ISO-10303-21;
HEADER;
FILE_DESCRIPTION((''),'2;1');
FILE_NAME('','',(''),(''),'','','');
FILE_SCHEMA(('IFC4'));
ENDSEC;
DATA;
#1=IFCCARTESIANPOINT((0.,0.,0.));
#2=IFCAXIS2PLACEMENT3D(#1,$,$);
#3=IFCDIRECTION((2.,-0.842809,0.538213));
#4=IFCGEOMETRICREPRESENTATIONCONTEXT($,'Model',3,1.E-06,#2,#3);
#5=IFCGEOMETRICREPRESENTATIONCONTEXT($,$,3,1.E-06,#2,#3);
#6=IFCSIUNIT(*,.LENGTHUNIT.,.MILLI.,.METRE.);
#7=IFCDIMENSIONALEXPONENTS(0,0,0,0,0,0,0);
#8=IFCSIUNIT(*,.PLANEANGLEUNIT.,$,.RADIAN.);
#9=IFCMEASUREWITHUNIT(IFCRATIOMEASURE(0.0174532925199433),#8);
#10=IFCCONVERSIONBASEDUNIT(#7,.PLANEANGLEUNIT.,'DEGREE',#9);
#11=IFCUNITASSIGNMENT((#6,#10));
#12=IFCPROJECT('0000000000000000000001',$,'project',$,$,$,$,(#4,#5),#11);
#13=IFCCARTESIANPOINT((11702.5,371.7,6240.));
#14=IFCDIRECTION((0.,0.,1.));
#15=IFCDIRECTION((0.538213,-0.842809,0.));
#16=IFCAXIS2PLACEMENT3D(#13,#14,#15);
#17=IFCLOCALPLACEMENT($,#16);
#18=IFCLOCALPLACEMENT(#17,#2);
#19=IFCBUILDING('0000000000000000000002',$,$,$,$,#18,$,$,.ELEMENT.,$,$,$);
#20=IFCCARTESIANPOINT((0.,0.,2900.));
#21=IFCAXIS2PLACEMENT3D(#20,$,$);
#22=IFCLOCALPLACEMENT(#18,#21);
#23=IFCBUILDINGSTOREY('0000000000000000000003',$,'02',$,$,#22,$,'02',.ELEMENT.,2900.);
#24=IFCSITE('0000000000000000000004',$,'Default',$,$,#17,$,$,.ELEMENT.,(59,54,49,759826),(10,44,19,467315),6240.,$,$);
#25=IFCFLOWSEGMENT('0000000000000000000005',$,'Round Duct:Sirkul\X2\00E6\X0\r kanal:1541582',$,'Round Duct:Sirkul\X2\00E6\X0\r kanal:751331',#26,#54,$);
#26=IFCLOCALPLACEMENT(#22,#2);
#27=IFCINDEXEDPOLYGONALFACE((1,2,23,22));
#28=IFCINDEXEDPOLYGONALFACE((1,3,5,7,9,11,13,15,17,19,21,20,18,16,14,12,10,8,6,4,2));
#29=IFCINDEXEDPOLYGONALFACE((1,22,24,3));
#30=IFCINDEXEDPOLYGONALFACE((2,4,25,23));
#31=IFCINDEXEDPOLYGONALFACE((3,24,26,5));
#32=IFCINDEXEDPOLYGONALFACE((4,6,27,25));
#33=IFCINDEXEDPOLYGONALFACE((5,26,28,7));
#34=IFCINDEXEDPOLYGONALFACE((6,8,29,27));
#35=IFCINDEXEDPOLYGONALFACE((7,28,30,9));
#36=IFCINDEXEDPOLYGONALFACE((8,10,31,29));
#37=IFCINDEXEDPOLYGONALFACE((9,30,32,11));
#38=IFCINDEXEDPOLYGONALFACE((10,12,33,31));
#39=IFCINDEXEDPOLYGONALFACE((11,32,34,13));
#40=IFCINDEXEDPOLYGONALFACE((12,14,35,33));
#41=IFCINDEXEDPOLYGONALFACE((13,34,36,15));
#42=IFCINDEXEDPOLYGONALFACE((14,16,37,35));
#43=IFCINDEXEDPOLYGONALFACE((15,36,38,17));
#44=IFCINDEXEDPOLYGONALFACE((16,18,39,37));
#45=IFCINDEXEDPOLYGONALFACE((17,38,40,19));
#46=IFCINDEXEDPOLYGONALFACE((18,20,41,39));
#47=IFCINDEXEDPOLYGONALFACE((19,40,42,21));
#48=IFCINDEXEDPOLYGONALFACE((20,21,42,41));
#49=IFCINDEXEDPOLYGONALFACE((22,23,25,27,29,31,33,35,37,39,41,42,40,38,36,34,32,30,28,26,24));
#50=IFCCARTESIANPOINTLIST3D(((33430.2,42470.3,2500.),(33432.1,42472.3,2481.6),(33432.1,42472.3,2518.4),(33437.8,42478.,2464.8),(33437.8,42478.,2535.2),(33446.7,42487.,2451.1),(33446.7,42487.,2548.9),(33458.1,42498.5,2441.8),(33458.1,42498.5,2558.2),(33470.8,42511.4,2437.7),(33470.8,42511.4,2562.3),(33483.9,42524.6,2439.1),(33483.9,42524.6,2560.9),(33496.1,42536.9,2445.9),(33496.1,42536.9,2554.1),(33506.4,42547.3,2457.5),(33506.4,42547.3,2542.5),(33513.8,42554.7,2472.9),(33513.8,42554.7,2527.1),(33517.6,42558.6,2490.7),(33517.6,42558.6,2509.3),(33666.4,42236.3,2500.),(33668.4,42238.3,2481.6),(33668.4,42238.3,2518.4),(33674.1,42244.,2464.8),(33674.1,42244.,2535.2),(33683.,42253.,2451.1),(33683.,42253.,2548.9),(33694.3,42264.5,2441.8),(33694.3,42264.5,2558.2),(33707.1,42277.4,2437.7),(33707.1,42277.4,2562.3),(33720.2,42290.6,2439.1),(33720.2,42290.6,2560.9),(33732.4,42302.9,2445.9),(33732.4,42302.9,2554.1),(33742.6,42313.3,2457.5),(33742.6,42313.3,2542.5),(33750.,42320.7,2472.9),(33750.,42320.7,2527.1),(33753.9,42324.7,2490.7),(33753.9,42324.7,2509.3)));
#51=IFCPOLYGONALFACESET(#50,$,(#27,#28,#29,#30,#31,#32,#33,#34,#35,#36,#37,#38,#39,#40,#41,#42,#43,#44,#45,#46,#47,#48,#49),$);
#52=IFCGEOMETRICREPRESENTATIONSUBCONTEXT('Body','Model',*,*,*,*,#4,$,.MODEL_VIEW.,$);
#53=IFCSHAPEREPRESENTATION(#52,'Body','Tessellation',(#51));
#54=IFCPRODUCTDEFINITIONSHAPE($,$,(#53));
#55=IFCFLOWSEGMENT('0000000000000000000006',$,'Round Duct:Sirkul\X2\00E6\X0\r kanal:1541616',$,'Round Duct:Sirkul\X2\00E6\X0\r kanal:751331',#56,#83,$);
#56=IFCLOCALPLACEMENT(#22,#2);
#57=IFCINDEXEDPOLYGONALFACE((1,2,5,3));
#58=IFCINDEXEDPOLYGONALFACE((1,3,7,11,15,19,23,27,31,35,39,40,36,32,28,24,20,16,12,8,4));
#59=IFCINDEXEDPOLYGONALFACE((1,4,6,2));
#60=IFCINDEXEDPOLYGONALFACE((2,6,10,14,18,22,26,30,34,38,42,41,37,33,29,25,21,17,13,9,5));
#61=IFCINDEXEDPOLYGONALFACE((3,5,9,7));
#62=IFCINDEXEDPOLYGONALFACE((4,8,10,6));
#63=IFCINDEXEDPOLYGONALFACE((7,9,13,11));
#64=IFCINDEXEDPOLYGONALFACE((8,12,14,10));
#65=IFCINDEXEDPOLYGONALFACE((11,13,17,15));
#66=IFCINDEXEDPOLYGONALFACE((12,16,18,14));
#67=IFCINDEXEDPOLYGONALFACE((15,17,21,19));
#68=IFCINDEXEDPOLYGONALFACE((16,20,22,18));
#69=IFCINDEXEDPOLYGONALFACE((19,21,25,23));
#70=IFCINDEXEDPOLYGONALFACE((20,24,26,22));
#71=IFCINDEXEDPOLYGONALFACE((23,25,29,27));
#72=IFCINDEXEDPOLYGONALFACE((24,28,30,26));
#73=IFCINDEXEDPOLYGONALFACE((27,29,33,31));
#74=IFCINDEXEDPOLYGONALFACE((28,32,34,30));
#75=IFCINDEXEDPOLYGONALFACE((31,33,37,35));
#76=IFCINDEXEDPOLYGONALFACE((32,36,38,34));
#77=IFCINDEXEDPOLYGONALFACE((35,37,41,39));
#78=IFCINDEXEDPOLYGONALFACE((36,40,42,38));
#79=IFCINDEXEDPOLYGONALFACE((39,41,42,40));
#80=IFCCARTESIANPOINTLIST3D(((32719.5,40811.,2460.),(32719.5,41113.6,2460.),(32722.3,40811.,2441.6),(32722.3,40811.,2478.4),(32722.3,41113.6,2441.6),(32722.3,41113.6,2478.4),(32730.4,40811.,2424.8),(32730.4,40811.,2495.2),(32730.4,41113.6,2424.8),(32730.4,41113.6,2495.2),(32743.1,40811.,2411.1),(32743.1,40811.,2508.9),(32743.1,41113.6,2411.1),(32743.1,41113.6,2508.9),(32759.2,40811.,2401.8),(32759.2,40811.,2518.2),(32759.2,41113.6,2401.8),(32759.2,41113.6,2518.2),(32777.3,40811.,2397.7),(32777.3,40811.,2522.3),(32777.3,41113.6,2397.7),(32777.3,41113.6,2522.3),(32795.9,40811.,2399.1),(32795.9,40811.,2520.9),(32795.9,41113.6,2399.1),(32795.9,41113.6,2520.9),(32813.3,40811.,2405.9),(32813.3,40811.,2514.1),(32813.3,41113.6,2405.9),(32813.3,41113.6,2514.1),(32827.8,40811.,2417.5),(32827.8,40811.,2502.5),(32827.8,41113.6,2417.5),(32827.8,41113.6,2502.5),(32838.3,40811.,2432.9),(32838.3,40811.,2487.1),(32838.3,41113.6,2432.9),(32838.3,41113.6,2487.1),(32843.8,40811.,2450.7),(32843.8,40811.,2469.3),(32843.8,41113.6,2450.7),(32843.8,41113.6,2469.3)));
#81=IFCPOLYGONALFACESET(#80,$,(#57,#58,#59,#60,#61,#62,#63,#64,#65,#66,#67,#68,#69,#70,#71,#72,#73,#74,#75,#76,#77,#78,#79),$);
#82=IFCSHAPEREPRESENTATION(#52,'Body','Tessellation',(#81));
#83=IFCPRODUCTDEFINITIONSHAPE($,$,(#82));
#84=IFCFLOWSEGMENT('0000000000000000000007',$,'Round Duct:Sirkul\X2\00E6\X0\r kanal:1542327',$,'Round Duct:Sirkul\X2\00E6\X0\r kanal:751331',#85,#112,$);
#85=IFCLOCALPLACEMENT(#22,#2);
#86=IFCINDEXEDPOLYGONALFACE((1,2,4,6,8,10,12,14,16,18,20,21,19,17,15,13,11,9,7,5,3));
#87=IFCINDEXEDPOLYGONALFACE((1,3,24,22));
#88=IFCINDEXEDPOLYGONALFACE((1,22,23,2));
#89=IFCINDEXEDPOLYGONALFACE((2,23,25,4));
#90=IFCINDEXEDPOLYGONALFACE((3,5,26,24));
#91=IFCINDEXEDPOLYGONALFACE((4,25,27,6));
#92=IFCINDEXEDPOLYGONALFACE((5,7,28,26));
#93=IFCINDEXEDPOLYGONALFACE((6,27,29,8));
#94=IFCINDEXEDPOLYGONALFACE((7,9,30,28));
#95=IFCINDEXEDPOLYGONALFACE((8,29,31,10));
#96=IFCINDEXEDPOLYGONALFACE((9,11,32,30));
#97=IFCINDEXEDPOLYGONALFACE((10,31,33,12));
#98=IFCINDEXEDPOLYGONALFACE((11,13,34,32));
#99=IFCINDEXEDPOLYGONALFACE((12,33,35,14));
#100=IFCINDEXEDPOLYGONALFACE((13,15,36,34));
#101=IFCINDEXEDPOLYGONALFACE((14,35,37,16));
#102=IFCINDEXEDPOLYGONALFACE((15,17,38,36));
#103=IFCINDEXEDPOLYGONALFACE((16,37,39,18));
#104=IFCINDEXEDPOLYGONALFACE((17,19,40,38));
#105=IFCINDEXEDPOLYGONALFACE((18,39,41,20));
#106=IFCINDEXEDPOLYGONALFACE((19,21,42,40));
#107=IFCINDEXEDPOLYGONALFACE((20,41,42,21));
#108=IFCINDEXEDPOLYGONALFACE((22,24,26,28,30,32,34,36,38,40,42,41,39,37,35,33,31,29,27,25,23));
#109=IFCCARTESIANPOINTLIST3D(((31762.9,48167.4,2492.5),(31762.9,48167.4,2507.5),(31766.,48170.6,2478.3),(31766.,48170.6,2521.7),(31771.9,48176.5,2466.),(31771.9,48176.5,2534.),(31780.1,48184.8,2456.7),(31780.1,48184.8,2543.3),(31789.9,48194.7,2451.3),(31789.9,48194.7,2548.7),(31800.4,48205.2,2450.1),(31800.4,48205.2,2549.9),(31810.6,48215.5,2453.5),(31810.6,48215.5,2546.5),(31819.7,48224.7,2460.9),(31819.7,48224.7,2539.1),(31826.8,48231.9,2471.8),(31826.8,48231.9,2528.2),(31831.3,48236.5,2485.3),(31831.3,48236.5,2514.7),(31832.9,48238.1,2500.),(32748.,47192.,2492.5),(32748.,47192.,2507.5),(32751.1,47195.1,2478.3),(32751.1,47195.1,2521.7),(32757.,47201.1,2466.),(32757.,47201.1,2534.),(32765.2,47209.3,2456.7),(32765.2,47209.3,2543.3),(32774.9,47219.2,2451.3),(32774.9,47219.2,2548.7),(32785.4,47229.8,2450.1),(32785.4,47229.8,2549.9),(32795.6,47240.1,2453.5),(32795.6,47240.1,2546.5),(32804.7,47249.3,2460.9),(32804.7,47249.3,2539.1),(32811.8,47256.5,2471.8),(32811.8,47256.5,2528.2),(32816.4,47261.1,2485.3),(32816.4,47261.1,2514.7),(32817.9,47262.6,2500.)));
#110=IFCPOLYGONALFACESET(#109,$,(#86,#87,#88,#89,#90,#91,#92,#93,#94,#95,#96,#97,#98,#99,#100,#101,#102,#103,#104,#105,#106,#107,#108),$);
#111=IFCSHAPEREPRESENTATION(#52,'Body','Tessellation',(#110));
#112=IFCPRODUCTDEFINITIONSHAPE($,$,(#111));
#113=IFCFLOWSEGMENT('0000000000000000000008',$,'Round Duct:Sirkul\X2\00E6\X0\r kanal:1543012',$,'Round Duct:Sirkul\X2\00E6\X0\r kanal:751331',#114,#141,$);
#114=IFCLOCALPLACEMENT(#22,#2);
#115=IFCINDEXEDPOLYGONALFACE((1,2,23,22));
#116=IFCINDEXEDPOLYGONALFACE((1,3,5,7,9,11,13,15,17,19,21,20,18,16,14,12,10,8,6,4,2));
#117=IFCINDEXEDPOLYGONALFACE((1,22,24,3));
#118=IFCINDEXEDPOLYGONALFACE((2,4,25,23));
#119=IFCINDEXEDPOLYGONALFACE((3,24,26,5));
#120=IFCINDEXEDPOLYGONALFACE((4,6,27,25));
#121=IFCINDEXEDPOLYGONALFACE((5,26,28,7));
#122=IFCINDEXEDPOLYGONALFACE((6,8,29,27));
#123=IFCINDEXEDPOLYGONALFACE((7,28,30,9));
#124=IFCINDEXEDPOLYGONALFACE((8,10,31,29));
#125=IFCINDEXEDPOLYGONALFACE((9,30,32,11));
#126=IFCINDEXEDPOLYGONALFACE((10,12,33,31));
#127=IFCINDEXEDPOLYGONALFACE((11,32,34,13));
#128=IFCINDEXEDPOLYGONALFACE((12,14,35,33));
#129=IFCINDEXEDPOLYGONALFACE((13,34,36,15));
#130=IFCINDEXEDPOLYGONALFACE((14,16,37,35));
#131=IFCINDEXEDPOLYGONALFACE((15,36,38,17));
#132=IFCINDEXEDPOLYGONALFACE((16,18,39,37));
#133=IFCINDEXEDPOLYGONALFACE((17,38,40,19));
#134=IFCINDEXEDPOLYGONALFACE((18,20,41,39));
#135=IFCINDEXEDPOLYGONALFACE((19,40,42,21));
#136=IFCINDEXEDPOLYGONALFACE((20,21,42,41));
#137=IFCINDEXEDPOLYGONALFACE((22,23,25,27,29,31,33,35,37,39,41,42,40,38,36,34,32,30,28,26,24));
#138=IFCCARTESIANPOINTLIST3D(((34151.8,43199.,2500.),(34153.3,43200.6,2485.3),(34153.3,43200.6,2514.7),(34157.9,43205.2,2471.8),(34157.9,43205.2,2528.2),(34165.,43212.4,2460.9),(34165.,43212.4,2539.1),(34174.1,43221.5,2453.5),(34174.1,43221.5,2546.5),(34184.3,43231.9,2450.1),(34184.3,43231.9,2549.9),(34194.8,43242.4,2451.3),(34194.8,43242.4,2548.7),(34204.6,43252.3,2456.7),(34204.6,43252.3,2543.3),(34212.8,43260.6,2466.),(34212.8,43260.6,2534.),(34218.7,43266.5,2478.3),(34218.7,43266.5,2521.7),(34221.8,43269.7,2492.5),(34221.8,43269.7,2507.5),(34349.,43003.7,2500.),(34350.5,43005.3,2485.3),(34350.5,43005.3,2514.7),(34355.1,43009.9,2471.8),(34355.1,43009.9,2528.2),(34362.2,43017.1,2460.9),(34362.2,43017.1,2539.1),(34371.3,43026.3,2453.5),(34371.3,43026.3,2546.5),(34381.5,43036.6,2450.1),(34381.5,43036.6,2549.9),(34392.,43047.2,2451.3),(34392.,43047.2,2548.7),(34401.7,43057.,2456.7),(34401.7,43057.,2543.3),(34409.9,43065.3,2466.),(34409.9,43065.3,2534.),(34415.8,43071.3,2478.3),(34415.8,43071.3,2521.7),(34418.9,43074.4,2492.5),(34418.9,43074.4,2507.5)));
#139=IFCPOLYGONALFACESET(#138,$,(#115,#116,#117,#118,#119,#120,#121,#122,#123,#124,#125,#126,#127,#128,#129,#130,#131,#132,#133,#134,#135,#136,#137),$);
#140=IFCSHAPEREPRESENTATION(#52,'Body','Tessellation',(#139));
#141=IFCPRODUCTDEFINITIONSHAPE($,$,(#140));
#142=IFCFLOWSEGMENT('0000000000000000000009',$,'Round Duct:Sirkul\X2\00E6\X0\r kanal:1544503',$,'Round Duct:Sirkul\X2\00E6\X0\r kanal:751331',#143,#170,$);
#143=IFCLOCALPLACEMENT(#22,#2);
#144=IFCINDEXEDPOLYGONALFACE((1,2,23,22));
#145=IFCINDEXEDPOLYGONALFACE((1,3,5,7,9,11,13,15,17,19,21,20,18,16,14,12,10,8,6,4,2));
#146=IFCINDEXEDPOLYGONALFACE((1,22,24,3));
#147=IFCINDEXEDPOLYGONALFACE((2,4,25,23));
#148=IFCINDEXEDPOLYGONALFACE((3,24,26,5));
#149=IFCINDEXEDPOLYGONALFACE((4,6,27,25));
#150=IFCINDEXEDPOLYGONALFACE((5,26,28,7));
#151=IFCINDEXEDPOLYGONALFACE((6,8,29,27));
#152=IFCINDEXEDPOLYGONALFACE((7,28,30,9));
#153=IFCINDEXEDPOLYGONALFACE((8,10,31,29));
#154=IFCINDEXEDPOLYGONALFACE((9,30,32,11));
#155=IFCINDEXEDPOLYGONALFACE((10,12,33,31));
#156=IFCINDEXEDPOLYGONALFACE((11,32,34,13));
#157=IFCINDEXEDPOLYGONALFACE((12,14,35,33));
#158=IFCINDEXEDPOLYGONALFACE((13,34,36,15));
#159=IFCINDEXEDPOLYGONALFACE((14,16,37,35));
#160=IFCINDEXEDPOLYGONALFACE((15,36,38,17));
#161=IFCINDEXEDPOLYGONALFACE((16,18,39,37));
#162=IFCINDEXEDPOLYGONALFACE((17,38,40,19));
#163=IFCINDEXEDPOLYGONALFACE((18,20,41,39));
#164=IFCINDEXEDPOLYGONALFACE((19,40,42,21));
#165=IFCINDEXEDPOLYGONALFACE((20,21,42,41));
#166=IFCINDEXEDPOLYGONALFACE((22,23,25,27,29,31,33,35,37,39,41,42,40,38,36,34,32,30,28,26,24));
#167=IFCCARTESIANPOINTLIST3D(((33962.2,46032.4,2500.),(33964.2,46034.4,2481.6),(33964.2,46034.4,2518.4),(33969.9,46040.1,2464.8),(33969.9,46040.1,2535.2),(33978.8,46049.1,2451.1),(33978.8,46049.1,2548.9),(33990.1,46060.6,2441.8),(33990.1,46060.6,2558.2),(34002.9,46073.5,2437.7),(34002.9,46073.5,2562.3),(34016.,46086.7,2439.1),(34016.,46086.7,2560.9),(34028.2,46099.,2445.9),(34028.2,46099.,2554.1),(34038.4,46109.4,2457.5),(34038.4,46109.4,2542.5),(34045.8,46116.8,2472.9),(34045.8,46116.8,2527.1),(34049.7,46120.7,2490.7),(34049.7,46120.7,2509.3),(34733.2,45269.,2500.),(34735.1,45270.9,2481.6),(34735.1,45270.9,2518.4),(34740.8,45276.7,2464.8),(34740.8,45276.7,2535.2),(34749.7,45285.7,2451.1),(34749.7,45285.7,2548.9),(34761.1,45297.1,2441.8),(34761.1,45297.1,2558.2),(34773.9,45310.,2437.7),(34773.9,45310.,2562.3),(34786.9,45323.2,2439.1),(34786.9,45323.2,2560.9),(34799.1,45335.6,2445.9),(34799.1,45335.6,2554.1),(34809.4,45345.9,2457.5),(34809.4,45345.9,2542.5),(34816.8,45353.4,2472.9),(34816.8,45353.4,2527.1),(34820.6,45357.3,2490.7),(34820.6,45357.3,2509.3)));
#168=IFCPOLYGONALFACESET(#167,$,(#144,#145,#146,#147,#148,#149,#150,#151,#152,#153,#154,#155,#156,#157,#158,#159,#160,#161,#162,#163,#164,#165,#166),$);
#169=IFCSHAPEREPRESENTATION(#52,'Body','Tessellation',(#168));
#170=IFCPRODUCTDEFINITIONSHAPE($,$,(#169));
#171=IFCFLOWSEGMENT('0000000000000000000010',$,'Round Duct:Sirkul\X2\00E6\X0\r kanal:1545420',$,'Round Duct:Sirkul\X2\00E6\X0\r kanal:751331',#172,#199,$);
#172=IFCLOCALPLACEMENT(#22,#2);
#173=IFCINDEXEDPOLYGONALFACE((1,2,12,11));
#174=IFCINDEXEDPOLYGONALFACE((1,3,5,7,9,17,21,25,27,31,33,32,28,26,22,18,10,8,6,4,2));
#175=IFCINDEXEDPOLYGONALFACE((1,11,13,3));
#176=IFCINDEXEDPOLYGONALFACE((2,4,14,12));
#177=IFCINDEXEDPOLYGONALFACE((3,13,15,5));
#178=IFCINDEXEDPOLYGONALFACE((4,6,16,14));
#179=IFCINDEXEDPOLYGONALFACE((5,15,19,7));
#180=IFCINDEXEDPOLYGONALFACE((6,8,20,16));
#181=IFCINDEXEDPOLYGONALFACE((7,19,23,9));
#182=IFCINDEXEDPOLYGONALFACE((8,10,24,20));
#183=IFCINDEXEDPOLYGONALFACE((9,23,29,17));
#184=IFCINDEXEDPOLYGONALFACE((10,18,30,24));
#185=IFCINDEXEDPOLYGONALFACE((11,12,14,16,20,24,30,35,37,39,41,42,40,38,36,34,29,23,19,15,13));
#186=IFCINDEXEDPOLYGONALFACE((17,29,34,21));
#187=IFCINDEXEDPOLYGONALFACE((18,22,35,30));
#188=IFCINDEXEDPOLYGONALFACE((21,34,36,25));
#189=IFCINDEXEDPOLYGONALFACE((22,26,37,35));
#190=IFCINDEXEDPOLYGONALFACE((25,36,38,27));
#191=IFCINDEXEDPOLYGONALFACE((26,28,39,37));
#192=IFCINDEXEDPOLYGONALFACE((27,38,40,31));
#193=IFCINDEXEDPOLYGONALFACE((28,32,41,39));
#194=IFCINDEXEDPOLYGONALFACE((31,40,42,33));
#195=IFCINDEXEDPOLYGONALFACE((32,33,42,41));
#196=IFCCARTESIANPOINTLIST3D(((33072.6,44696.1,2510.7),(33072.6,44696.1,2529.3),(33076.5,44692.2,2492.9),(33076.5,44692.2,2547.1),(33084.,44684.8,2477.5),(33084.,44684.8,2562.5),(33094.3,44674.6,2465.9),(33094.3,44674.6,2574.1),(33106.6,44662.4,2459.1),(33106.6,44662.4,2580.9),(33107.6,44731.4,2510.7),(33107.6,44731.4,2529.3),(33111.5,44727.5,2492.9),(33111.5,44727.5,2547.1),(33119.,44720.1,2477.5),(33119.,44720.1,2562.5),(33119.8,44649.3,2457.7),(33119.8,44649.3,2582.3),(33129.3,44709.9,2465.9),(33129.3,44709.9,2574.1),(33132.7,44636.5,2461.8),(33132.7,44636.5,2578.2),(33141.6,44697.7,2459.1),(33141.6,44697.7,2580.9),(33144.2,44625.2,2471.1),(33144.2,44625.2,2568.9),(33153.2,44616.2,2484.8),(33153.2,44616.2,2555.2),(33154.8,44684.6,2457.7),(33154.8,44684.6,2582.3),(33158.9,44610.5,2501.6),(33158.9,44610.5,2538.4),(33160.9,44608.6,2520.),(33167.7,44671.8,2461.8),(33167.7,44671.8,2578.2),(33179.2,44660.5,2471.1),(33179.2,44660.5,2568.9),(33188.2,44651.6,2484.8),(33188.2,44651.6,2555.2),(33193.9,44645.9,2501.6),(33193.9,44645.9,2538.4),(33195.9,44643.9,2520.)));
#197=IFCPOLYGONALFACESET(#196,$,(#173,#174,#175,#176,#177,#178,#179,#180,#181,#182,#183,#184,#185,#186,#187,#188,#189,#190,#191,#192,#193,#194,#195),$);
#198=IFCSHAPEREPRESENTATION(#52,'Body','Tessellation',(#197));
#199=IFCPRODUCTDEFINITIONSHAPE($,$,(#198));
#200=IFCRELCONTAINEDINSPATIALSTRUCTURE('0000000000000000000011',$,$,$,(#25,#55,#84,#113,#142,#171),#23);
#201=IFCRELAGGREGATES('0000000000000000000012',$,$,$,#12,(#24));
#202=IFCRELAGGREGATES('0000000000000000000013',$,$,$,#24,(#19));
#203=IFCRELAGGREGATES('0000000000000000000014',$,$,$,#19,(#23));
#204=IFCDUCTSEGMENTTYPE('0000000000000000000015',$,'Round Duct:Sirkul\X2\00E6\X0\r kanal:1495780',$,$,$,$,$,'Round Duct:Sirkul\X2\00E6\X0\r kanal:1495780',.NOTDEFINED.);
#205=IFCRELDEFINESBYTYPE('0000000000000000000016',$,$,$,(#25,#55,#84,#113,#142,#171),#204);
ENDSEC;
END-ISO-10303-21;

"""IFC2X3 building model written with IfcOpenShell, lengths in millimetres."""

from ifc_helpers import new_model, entity, si_unit, converted_unit, direction, frame, frame_2d, origin, origin_2d_with_axis, place, context, subcontext, project, spatial, circle, extrude, type_object, element, save


model = new_model("IFC2X3")

# Units and contexts
model_context = context("Model", 3, precision=1e-06, world=origin(), true_north=direction((2.0, -0.842809, 0.538213)))
context_of_model = context(None, 3, precision=1e-06, world=origin(), true_north=direction((2.0, -0.842809, 0.538213)))
body_context = subcontext(model_context, "Body", "Model", "MODEL_VIEW")
ifc_project = project(units=[si_unit("LENGTHUNIT", "METRE", prefix="MILLI"), converted_unit("PLANEANGLEUNIT", "DEGREE", entity("IfcRatioMeasure", 0.0174532925199433), si_unit("PLANEANGLEUNIT", "RADIAN"), dimensions=[0, 0, 0, 0, 0, 0, 0])], contexts=[model_context, context_of_model])

# Site, building, storey
site_placement = place(None, frame((11702.5, 371.7, 6240.0), z_axis=(0.0, 0.0, 1.0), x_axis=(0.538213, -0.842809, 0.0)))
site = spatial("IfcSite", under=ifc_project, at=site_placement, Name="Default", CompositionType="ELEMENT", RefLatitude=(59, 54, 49, 759826), RefLongitude=(10, 44, 19, 467315), RefElevation=6240.0)
building_placement = place(site_placement, origin())
building = spatial("IfcBuilding", under=site, at=building_placement, CompositionType="ELEMENT")
storey_placement = place(building_placement, frame((0.0, 0.0, 2900.0)))
storey = spatial("IfcBuildingStorey", under=building, at=storey_placement, Name="02", LongName="02", CompositionType="ELEMENT", Elevation=2900.0)

# Flow segments
duct_segment_type_1 = type_object("IfcDuctSegmentType", Name="Round Duct:Sirkulær kanal:1495780", ElementType="Round Duct:Sirkulær kanal:1495780", PredefinedType="NOTDEFINED")
flow_segment_1_placement = place(storey_placement, origin())
element("IfcFlowSegment", 1, at=flow_segment_1_placement, inside=storey, type_object=duct_segment_type_1, Name="Round Duct:Sirkulær kanal:1541582", ObjectType="Round Duct:Sirkulær kanal:751331", context=body_context, shape_type="SweptSolid", body=[
    extrude(circle(Radius=62.5, at=origin_2d_with_axis()), frame((33710.4, 42280.7, 2500.0), z_axis=(-0.710554, 0.703643, 0.0), x_axis=(-0.703643, -0.710554, 0.0)), (0.0, 0.0, 1.0), 332.5),
])
flow_segment_2_placement = place(storey_placement, origin())
element("IfcFlowSegment", 2, at=flow_segment_2_placement, inside=storey, type_object=duct_segment_type_1, Name="Round Duct:Sirkulær kanal:1541616", ObjectType="Round Duct:Sirkulær kanal:751331", context=body_context, shape_type="SweptSolid", body=[
    extrude(circle(Radius=62.5, at=frame_2d((0.0, 0.0), x_axis=(1.0, 0.0))), frame((32782.0, 40811.0, 2460.0), z_axis=(0.0, 1.0, 0.0), x_axis=(-1.0, 0.0, 0.0)), (0.0, 0.0, 1.0), 302.6),
])
flow_segment_3_placement = place(storey_placement, origin())
element("IfcFlowSegment", 3, at=flow_segment_3_placement, inside=storey, type_object=duct_segment_type_1, Name="Round Duct:Sirkulær kanal:1542327", ObjectType="Round Duct:Sirkulær kanal:751331", context=body_context, shape_type="SweptSolid", body=[
    extrude(circle(Radius=50.0, at=origin_2d_with_axis()), frame((32782.8, 47227.1, 2500.0), z_axis=(-0.710554, 0.703643, 0.0), x_axis=(0.703643, 0.710554, 0.0)), (0.0, 0.0, 1.0), 1386.3),
])
flow_segment_4_placement = place(storey_placement, origin())
element("IfcFlowSegment", 4, at=flow_segment_4_placement, inside=storey, type_object=duct_segment_type_1, Name="Round Duct:Sirkulær kanal:1543012", ObjectType="Round Duct:Sirkulær kanal:751331", context=body_context, shape_type="SweptSolid", body=[
    extrude(circle(Radius=50.0, at=origin_2d_with_axis()), frame((34187.0, 43234.5, 2500.0), z_axis=(0.710554, -0.703643, 0.0), x_axis=(-0.703643, -0.710554, 0.0)), (0.0, 0.0, 1.0), 277.5),
])
flow_segment_5_placement = place(storey_placement, origin())
element("IfcFlowSegment", 5, at=flow_segment_5_placement, inside=storey, type_object=duct_segment_type_1, Name="Round Duct:Sirkulær kanal:1544503", ObjectType="Round Duct:Sirkulær kanal:751331", context=body_context, shape_type="SweptSolid", body=[
    extrude(circle(Radius=62.5, at=origin_2d_with_axis()), frame((34006.2, 46076.8, 2500.0), z_axis=(0.710554, -0.703643, 0.0), x_axis=(-0.703643, -0.710554, 0.0)), (0.0, 0.0, 1.0), 1085.0),
])
flow_segment_6_placement = place(storey_placement, origin())
element("IfcFlowSegment", 6, at=flow_segment_6_placement, inside=storey, type_object=duct_segment_type_1, Name="Round Duct:Sirkulær kanal:1545420", ObjectType="Round Duct:Sirkulær kanal:751331", context=body_context, shape_type="SweptSolid", body=[
    extrude(circle(Radius=62.5, at=origin_2d_with_axis()), frame((33116.5, 44652.6, 2520.0), z_axis=(0.703643, 0.710554, 0.0), x_axis=(0.710554, -0.703643, 0.0)), (0.0, 0.0, 1.0), 49.7),
])

save(model, "model.ifc")
